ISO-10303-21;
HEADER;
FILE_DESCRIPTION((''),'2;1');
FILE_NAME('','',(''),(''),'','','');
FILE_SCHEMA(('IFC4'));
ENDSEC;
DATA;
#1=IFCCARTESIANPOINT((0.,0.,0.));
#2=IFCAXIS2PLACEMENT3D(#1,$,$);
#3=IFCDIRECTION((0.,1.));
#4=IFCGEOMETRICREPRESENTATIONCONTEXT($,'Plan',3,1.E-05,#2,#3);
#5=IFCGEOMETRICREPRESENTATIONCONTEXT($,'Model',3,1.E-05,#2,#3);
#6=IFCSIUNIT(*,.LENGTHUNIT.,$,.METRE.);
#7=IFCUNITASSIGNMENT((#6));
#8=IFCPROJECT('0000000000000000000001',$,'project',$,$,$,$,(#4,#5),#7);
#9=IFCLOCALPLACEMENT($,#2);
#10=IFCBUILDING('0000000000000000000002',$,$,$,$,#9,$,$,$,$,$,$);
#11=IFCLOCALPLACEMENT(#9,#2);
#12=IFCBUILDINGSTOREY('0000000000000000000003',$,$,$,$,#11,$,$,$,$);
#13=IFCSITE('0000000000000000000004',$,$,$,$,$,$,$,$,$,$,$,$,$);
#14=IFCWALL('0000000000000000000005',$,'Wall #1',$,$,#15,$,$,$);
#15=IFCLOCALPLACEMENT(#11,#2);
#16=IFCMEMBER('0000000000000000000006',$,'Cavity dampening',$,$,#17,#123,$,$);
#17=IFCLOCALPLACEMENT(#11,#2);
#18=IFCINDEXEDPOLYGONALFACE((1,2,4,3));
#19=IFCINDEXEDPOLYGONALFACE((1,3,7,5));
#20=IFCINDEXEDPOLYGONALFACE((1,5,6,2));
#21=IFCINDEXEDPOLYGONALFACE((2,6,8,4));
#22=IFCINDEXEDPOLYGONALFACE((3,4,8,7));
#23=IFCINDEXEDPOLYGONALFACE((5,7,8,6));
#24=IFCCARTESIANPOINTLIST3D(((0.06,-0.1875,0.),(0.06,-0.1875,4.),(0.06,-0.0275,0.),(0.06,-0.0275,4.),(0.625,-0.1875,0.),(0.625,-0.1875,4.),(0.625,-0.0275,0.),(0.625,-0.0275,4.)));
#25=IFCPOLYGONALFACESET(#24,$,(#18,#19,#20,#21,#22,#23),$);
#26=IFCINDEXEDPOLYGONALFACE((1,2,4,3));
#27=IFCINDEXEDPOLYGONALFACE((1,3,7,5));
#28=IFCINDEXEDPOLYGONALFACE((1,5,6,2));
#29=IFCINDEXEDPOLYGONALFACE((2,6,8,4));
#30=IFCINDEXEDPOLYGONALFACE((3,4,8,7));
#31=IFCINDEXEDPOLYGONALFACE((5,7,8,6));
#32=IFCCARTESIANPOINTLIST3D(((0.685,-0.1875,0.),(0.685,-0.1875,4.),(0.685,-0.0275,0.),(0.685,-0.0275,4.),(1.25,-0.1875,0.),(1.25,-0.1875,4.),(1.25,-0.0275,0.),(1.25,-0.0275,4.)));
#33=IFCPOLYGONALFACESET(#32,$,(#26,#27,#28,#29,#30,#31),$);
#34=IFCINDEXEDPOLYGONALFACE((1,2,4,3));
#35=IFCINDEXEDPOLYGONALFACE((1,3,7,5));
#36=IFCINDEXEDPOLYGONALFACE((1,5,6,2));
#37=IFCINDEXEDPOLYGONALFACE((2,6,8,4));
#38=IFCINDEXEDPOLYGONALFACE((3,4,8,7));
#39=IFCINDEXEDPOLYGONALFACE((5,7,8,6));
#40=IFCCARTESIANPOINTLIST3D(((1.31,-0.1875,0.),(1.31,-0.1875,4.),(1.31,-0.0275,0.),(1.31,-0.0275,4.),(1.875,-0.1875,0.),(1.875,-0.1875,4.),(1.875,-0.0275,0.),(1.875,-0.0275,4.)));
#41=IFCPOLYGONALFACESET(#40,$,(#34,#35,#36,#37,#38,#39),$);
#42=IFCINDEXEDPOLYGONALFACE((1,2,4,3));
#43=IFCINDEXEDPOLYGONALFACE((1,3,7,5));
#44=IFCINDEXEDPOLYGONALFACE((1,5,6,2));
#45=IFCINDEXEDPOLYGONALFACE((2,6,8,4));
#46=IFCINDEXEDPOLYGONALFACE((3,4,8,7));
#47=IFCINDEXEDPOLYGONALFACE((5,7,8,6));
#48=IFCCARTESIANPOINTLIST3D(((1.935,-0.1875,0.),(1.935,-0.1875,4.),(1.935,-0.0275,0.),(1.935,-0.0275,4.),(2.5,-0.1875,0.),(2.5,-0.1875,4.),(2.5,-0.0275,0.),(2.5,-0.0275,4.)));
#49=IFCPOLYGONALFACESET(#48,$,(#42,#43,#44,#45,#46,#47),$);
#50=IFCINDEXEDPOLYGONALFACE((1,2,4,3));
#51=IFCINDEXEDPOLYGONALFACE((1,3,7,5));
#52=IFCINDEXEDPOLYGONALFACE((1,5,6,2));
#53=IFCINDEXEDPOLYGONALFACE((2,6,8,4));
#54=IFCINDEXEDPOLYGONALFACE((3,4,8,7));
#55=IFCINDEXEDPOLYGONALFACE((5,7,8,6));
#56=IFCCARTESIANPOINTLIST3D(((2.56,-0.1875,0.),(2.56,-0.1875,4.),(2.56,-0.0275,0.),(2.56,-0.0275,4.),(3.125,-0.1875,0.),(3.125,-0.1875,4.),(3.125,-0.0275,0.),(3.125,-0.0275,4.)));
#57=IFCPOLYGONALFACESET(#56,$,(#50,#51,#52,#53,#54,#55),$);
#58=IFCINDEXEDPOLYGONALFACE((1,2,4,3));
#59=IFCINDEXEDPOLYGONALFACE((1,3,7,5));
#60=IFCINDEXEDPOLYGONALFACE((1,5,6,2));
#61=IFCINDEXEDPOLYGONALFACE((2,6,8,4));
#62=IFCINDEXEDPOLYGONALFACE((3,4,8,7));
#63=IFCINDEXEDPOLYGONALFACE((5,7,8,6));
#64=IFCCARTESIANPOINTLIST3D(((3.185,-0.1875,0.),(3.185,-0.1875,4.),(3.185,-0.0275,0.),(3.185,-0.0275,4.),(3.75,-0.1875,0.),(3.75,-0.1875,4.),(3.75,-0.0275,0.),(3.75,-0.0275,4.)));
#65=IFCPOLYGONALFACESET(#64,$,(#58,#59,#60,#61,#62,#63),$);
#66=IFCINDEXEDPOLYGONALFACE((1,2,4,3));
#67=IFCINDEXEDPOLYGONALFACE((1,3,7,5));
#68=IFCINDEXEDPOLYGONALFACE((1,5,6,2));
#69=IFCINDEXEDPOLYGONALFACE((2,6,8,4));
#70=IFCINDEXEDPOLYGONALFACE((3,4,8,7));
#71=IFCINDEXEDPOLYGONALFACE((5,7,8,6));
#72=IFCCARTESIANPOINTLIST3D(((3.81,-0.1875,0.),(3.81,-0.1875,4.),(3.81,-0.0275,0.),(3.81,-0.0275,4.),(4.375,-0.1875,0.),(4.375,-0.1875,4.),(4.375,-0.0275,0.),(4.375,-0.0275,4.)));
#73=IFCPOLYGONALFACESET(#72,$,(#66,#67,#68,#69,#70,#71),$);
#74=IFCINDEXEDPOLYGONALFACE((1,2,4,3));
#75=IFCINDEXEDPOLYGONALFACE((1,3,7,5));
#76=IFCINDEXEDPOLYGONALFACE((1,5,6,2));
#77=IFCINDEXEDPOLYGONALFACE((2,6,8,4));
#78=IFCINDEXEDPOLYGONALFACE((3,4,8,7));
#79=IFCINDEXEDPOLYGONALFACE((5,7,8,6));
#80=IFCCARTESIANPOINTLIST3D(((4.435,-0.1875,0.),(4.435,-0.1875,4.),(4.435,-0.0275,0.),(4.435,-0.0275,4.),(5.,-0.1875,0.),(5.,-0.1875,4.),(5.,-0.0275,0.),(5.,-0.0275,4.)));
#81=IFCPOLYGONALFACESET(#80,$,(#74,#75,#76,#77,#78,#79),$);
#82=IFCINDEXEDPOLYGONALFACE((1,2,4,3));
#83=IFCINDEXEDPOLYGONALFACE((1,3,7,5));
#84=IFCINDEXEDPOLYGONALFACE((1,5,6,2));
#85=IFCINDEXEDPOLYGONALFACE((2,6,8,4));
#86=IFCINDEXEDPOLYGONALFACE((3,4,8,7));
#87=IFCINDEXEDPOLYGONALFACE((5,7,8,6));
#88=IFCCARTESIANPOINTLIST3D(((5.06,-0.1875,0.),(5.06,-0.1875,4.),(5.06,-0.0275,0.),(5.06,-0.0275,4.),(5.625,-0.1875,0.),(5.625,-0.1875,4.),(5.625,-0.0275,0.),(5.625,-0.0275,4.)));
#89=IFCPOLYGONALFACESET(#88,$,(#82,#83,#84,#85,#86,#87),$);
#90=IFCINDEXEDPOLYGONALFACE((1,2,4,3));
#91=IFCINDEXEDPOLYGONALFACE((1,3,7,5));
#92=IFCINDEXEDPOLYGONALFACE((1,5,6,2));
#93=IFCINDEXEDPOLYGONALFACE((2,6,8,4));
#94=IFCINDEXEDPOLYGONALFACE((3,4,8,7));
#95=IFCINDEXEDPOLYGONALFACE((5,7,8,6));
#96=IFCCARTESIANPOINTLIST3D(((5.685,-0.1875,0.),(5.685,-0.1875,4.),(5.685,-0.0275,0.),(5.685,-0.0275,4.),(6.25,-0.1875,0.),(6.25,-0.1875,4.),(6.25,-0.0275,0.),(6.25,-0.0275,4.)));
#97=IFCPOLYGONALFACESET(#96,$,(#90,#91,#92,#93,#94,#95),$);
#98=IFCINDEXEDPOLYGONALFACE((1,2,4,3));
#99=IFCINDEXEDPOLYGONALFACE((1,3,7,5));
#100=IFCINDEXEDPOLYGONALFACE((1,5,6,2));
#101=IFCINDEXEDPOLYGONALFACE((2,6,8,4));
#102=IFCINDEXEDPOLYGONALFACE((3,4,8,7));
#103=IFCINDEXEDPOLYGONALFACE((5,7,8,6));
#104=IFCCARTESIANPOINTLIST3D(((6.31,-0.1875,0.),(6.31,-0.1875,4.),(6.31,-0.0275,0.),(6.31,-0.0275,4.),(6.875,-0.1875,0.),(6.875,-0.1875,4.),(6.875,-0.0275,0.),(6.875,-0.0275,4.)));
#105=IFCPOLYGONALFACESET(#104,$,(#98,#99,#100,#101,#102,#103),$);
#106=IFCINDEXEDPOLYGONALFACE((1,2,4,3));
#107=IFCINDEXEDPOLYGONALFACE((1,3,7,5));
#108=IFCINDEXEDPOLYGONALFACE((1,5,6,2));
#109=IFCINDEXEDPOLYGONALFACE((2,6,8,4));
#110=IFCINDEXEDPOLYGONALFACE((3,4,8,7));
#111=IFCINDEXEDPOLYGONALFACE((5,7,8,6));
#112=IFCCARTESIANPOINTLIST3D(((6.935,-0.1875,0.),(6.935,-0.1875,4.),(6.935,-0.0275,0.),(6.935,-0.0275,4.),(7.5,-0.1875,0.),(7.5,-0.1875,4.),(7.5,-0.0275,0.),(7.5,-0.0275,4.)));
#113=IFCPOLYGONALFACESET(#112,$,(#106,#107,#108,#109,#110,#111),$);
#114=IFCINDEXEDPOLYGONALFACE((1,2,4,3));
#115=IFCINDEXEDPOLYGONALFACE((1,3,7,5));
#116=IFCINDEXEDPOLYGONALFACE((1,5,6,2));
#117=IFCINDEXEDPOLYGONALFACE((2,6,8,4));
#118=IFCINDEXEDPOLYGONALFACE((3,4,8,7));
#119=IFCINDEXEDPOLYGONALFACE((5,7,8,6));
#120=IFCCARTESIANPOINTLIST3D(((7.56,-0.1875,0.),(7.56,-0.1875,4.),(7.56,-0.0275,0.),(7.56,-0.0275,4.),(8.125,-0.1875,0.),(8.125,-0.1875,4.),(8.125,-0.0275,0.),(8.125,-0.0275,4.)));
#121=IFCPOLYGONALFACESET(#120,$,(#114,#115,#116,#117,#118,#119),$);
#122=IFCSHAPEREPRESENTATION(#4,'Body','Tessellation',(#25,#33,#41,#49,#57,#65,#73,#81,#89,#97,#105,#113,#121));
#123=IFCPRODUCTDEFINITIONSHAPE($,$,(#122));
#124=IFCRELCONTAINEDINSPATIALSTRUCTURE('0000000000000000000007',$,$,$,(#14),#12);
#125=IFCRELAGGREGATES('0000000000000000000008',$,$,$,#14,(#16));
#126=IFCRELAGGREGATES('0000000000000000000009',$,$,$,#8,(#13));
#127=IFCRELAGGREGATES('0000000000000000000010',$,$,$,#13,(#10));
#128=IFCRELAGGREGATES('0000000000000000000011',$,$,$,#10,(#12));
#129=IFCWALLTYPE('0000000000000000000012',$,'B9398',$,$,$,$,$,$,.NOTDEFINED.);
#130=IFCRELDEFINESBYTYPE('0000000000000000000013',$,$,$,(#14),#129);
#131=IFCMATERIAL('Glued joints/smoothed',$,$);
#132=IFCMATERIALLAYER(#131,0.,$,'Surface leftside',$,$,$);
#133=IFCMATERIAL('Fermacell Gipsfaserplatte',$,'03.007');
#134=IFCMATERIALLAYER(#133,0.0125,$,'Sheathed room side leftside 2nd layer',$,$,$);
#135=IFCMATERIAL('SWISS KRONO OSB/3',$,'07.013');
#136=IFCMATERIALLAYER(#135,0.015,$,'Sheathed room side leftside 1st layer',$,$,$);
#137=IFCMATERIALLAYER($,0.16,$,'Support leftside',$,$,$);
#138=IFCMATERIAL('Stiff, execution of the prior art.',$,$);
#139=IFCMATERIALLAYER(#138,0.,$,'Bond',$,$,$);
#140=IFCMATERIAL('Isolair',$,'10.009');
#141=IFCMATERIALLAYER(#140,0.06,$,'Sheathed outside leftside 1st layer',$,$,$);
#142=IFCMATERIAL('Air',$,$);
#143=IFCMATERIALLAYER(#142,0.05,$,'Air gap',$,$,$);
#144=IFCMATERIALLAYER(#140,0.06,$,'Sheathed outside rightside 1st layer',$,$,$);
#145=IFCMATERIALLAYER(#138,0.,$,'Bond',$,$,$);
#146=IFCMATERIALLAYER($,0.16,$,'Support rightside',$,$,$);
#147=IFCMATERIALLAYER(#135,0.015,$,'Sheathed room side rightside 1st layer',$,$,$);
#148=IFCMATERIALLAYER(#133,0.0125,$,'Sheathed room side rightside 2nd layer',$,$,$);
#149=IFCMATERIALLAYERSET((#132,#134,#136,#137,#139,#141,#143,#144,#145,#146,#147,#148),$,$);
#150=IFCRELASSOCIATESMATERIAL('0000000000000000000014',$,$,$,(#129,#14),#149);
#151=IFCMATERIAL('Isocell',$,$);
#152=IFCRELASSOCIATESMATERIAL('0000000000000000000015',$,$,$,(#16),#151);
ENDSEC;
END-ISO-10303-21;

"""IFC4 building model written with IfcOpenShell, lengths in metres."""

from ifc_helpers import new_model, si_unit, direction, frame, frame_2d, origin, place, context, project, spatial, rectangle, extrude, material, layer, layer_set, type_object, element, aggregate, save


model = new_model("IFC4")

# Units and contexts
plan_context = context("Plan", 3, precision=1e-05, world=origin(), true_north=direction((0.0, 1.0)))
model_context = context("Model", 3, precision=1e-05, world=origin(), true_north=direction((0.0, 1.0)))
ifc_project = project(units=[si_unit("LENGTHUNIT", "METRE")], contexts=[plan_context, model_context])

# Site, building, storey
site = spatial("IfcSite", under=ifc_project)
building_placement = place(None, origin())
building = spatial("IfcBuilding", under=site, at=building_placement)
storey_placement = place(building_placement, origin())
storey = spatial("IfcBuildingStorey", under=building, at=storey_placement)

# Wall, member
ifc_material_1 = material(Name="Glued joints/smoothed")
ifc_layer_1 = layer(ifc_material_1, 0.0, Name="Surface leftside")
ifc_material_2 = material(Name="Fermacell Gipsfaserplatte", Category="03.007")
ifc_layer_2 = layer(ifc_material_2, 0.0125, Name="Sheathed room side leftside 2nd layer")
ifc_material_3 = material(Name="SWISS KRONO OSB/3", Category="07.013")
ifc_layer_3 = layer(ifc_material_3, 0.015, Name="Sheathed room side leftside 1st layer")
ifc_layer_4 = layer(None, 0.16, Name="Support leftside")
ifc_material_4 = material(Name="Stiff, execution of the prior art.")
ifc_layer_5 = layer(ifc_material_4, 0.0, Name="Bond")
ifc_material_5 = material(Name="Isolair", Category="10.009")
ifc_layer_6 = layer(ifc_material_5, 0.06, Name="Sheathed outside leftside 1st layer")
ifc_material_6 = material(Name="Air")
ifc_layer_7 = layer(ifc_material_6, 0.05, Name="Air gap")
ifc_layer_8 = layer(ifc_material_5, 0.06, Name="Sheathed outside rightside 1st layer")
ifc_layer_9 = layer(ifc_material_4, 0.0, Name="Bond")
ifc_layer_10 = layer(None, 0.16, Name="Support rightside")
ifc_layer_11 = layer(ifc_material_3, 0.015, Name="Sheathed room side rightside 1st layer")
ifc_layer_12 = layer(ifc_material_2, 0.0125, Name="Sheathed room side rightside 2nd layer")
ifc_layer_set = layer_set([ifc_layer_1, ifc_layer_2, ifc_layer_3, ifc_layer_4, ifc_layer_5, ifc_layer_6, ifc_layer_7, ifc_layer_8, ifc_layer_9, ifc_layer_10, ifc_layer_11, ifc_layer_12])
wall_type = type_object("IfcWallType", Name="B9398", PredefinedType="NOTDEFINED", material=ifc_layer_set)
wall_placement = place(None, frame((0.0, 0.0, 0.0), z_axis=(0.0, -1.0, 0.0), x_axis=(1.0, 0.0, 0.0)))
wall = element("IfcWall", 1, at=wall_placement, inside=storey, type_object=wall_type, material=ifc_layer_set, Name="Wall #1")
ifc_material_7 = material(Name="Isocell")
member_1_placement = place(wall_placement, origin())
member_1 = element("IfcMember", 2, at=member_1_placement, material=ifc_material_7, Name="Cavity dampening", context=plan_context, shape_type="SweptSolid", body=[
    extrude(rectangle(XDim=0.565, YDim=0.16, at=frame_2d((0.2825, 0.08), x_axis=(1.0, 0.0))), frame((0.06, 4.0, 0.0275), z_axis=(0.0, -1.0, 0.0), x_axis=(1.0, 0.0, 0.0)), (0.0, 0.0, 1.0), 4.0),
    extrude(rectangle(XDim=0.565, YDim=0.16, at=frame_2d((0.2825, 0.08), x_axis=(1.0, 0.0))), frame((0.685, 4.0, 0.0275), z_axis=(0.0, -1.0, 0.0), x_axis=(1.0, 0.0, 0.0)), (0.0, 0.0, 1.0), 4.0),
    extrude(rectangle(XDim=0.565, YDim=0.16, at=frame_2d((0.2825, 0.08), x_axis=(1.0, 0.0))), frame((1.31, 4.0, 0.0275), z_axis=(0.0, -1.0, 0.0), x_axis=(1.0, 0.0, 0.0)), (0.0, 0.0, 1.0), 4.0),
    extrude(rectangle(XDim=0.565, YDim=0.16, at=frame_2d((0.2825, 0.08), x_axis=(1.0, 0.0))), frame((1.935, 4.0, 0.0275), z_axis=(0.0, -1.0, 0.0), x_axis=(1.0, 0.0, 0.0)), (0.0, 0.0, 1.0), 4.0),
    extrude(rectangle(XDim=0.565, YDim=0.16, at=frame_2d((0.2825, 0.08), x_axis=(1.0, 0.0))), frame((2.56, 4.0, 0.0275), z_axis=(0.0, -1.0, 0.0), x_axis=(1.0, 0.0, 0.0)), (0.0, 0.0, 1.0), 4.0),
    extrude(rectangle(XDim=0.565, YDim=0.16, at=frame_2d((0.2825, 0.08), x_axis=(1.0, 0.0))), frame((3.185, 4.0, 0.0275), z_axis=(0.0, -1.0, 0.0), x_axis=(1.0, 0.0, 0.0)), (0.0, 0.0, 1.0), 4.0),
    extrude(rectangle(XDim=0.565, YDim=0.16, at=frame_2d((0.2825, 0.08), x_axis=(1.0, 0.0))), frame((3.81, 4.0, 0.0275), z_axis=(0.0, -1.0, 0.0), x_axis=(1.0, 0.0, 0.0)), (0.0, 0.0, 1.0), 4.0),
    extrude(rectangle(XDim=0.565, YDim=0.16, at=frame_2d((0.2825, 0.08), x_axis=(1.0, 0.0))), frame((4.435, 4.0, 0.0275), z_axis=(0.0, -1.0, 0.0), x_axis=(1.0, 0.0, 0.0)), (0.0, 0.0, 1.0), 4.0),
    extrude(rectangle(XDim=0.565, YDim=0.16, at=frame_2d((0.2825, 0.08), x_axis=(1.0, 0.0))), frame((5.06, 4.0, 0.0275), z_axis=(0.0, -1.0, 0.0), x_axis=(1.0, 0.0, 0.0)), (0.0, 0.0, 1.0), 4.0),
    extrude(rectangle(XDim=0.565, YDim=0.16, at=frame_2d((0.2825, 0.08), x_axis=(1.0, 0.0))), frame((5.685, 4.0, 0.0275), z_axis=(0.0, -1.0, 0.0), x_axis=(1.0, 0.0, 0.0)), (0.0, 0.0, 1.0), 4.0),
    extrude(rectangle(XDim=0.565, YDim=0.16, at=frame_2d((0.2825, 0.08), x_axis=(1.0, 0.0))), frame((6.31, 4.0, 0.0275), z_axis=(0.0, -1.0, 0.0), x_axis=(1.0, 0.0, 0.0)), (0.0, 0.0, 1.0), 4.0),
    extrude(rectangle(XDim=0.565, YDim=0.16, at=frame_2d((0.2825, 0.08), x_axis=(1.0, 0.0))), frame((6.935, 4.0, 0.0275), z_axis=(0.0, -1.0, 0.0), x_axis=(1.0, 0.0, 0.0)), (0.0, 0.0, 1.0), 4.0),
    extrude(rectangle(XDim=0.565, YDim=0.16, at=frame_2d((0.2825, 0.08), x_axis=(1.0, 0.0))), frame((7.56, 4.0, 0.0275), z_axis=(0.0, -1.0, 0.0), x_axis=(1.0, 0.0, 0.0)), (0.0, 0.0, 1.0), 4.0),
])
aggregate(wall, [member_1])

save(model, "model.ifc")
